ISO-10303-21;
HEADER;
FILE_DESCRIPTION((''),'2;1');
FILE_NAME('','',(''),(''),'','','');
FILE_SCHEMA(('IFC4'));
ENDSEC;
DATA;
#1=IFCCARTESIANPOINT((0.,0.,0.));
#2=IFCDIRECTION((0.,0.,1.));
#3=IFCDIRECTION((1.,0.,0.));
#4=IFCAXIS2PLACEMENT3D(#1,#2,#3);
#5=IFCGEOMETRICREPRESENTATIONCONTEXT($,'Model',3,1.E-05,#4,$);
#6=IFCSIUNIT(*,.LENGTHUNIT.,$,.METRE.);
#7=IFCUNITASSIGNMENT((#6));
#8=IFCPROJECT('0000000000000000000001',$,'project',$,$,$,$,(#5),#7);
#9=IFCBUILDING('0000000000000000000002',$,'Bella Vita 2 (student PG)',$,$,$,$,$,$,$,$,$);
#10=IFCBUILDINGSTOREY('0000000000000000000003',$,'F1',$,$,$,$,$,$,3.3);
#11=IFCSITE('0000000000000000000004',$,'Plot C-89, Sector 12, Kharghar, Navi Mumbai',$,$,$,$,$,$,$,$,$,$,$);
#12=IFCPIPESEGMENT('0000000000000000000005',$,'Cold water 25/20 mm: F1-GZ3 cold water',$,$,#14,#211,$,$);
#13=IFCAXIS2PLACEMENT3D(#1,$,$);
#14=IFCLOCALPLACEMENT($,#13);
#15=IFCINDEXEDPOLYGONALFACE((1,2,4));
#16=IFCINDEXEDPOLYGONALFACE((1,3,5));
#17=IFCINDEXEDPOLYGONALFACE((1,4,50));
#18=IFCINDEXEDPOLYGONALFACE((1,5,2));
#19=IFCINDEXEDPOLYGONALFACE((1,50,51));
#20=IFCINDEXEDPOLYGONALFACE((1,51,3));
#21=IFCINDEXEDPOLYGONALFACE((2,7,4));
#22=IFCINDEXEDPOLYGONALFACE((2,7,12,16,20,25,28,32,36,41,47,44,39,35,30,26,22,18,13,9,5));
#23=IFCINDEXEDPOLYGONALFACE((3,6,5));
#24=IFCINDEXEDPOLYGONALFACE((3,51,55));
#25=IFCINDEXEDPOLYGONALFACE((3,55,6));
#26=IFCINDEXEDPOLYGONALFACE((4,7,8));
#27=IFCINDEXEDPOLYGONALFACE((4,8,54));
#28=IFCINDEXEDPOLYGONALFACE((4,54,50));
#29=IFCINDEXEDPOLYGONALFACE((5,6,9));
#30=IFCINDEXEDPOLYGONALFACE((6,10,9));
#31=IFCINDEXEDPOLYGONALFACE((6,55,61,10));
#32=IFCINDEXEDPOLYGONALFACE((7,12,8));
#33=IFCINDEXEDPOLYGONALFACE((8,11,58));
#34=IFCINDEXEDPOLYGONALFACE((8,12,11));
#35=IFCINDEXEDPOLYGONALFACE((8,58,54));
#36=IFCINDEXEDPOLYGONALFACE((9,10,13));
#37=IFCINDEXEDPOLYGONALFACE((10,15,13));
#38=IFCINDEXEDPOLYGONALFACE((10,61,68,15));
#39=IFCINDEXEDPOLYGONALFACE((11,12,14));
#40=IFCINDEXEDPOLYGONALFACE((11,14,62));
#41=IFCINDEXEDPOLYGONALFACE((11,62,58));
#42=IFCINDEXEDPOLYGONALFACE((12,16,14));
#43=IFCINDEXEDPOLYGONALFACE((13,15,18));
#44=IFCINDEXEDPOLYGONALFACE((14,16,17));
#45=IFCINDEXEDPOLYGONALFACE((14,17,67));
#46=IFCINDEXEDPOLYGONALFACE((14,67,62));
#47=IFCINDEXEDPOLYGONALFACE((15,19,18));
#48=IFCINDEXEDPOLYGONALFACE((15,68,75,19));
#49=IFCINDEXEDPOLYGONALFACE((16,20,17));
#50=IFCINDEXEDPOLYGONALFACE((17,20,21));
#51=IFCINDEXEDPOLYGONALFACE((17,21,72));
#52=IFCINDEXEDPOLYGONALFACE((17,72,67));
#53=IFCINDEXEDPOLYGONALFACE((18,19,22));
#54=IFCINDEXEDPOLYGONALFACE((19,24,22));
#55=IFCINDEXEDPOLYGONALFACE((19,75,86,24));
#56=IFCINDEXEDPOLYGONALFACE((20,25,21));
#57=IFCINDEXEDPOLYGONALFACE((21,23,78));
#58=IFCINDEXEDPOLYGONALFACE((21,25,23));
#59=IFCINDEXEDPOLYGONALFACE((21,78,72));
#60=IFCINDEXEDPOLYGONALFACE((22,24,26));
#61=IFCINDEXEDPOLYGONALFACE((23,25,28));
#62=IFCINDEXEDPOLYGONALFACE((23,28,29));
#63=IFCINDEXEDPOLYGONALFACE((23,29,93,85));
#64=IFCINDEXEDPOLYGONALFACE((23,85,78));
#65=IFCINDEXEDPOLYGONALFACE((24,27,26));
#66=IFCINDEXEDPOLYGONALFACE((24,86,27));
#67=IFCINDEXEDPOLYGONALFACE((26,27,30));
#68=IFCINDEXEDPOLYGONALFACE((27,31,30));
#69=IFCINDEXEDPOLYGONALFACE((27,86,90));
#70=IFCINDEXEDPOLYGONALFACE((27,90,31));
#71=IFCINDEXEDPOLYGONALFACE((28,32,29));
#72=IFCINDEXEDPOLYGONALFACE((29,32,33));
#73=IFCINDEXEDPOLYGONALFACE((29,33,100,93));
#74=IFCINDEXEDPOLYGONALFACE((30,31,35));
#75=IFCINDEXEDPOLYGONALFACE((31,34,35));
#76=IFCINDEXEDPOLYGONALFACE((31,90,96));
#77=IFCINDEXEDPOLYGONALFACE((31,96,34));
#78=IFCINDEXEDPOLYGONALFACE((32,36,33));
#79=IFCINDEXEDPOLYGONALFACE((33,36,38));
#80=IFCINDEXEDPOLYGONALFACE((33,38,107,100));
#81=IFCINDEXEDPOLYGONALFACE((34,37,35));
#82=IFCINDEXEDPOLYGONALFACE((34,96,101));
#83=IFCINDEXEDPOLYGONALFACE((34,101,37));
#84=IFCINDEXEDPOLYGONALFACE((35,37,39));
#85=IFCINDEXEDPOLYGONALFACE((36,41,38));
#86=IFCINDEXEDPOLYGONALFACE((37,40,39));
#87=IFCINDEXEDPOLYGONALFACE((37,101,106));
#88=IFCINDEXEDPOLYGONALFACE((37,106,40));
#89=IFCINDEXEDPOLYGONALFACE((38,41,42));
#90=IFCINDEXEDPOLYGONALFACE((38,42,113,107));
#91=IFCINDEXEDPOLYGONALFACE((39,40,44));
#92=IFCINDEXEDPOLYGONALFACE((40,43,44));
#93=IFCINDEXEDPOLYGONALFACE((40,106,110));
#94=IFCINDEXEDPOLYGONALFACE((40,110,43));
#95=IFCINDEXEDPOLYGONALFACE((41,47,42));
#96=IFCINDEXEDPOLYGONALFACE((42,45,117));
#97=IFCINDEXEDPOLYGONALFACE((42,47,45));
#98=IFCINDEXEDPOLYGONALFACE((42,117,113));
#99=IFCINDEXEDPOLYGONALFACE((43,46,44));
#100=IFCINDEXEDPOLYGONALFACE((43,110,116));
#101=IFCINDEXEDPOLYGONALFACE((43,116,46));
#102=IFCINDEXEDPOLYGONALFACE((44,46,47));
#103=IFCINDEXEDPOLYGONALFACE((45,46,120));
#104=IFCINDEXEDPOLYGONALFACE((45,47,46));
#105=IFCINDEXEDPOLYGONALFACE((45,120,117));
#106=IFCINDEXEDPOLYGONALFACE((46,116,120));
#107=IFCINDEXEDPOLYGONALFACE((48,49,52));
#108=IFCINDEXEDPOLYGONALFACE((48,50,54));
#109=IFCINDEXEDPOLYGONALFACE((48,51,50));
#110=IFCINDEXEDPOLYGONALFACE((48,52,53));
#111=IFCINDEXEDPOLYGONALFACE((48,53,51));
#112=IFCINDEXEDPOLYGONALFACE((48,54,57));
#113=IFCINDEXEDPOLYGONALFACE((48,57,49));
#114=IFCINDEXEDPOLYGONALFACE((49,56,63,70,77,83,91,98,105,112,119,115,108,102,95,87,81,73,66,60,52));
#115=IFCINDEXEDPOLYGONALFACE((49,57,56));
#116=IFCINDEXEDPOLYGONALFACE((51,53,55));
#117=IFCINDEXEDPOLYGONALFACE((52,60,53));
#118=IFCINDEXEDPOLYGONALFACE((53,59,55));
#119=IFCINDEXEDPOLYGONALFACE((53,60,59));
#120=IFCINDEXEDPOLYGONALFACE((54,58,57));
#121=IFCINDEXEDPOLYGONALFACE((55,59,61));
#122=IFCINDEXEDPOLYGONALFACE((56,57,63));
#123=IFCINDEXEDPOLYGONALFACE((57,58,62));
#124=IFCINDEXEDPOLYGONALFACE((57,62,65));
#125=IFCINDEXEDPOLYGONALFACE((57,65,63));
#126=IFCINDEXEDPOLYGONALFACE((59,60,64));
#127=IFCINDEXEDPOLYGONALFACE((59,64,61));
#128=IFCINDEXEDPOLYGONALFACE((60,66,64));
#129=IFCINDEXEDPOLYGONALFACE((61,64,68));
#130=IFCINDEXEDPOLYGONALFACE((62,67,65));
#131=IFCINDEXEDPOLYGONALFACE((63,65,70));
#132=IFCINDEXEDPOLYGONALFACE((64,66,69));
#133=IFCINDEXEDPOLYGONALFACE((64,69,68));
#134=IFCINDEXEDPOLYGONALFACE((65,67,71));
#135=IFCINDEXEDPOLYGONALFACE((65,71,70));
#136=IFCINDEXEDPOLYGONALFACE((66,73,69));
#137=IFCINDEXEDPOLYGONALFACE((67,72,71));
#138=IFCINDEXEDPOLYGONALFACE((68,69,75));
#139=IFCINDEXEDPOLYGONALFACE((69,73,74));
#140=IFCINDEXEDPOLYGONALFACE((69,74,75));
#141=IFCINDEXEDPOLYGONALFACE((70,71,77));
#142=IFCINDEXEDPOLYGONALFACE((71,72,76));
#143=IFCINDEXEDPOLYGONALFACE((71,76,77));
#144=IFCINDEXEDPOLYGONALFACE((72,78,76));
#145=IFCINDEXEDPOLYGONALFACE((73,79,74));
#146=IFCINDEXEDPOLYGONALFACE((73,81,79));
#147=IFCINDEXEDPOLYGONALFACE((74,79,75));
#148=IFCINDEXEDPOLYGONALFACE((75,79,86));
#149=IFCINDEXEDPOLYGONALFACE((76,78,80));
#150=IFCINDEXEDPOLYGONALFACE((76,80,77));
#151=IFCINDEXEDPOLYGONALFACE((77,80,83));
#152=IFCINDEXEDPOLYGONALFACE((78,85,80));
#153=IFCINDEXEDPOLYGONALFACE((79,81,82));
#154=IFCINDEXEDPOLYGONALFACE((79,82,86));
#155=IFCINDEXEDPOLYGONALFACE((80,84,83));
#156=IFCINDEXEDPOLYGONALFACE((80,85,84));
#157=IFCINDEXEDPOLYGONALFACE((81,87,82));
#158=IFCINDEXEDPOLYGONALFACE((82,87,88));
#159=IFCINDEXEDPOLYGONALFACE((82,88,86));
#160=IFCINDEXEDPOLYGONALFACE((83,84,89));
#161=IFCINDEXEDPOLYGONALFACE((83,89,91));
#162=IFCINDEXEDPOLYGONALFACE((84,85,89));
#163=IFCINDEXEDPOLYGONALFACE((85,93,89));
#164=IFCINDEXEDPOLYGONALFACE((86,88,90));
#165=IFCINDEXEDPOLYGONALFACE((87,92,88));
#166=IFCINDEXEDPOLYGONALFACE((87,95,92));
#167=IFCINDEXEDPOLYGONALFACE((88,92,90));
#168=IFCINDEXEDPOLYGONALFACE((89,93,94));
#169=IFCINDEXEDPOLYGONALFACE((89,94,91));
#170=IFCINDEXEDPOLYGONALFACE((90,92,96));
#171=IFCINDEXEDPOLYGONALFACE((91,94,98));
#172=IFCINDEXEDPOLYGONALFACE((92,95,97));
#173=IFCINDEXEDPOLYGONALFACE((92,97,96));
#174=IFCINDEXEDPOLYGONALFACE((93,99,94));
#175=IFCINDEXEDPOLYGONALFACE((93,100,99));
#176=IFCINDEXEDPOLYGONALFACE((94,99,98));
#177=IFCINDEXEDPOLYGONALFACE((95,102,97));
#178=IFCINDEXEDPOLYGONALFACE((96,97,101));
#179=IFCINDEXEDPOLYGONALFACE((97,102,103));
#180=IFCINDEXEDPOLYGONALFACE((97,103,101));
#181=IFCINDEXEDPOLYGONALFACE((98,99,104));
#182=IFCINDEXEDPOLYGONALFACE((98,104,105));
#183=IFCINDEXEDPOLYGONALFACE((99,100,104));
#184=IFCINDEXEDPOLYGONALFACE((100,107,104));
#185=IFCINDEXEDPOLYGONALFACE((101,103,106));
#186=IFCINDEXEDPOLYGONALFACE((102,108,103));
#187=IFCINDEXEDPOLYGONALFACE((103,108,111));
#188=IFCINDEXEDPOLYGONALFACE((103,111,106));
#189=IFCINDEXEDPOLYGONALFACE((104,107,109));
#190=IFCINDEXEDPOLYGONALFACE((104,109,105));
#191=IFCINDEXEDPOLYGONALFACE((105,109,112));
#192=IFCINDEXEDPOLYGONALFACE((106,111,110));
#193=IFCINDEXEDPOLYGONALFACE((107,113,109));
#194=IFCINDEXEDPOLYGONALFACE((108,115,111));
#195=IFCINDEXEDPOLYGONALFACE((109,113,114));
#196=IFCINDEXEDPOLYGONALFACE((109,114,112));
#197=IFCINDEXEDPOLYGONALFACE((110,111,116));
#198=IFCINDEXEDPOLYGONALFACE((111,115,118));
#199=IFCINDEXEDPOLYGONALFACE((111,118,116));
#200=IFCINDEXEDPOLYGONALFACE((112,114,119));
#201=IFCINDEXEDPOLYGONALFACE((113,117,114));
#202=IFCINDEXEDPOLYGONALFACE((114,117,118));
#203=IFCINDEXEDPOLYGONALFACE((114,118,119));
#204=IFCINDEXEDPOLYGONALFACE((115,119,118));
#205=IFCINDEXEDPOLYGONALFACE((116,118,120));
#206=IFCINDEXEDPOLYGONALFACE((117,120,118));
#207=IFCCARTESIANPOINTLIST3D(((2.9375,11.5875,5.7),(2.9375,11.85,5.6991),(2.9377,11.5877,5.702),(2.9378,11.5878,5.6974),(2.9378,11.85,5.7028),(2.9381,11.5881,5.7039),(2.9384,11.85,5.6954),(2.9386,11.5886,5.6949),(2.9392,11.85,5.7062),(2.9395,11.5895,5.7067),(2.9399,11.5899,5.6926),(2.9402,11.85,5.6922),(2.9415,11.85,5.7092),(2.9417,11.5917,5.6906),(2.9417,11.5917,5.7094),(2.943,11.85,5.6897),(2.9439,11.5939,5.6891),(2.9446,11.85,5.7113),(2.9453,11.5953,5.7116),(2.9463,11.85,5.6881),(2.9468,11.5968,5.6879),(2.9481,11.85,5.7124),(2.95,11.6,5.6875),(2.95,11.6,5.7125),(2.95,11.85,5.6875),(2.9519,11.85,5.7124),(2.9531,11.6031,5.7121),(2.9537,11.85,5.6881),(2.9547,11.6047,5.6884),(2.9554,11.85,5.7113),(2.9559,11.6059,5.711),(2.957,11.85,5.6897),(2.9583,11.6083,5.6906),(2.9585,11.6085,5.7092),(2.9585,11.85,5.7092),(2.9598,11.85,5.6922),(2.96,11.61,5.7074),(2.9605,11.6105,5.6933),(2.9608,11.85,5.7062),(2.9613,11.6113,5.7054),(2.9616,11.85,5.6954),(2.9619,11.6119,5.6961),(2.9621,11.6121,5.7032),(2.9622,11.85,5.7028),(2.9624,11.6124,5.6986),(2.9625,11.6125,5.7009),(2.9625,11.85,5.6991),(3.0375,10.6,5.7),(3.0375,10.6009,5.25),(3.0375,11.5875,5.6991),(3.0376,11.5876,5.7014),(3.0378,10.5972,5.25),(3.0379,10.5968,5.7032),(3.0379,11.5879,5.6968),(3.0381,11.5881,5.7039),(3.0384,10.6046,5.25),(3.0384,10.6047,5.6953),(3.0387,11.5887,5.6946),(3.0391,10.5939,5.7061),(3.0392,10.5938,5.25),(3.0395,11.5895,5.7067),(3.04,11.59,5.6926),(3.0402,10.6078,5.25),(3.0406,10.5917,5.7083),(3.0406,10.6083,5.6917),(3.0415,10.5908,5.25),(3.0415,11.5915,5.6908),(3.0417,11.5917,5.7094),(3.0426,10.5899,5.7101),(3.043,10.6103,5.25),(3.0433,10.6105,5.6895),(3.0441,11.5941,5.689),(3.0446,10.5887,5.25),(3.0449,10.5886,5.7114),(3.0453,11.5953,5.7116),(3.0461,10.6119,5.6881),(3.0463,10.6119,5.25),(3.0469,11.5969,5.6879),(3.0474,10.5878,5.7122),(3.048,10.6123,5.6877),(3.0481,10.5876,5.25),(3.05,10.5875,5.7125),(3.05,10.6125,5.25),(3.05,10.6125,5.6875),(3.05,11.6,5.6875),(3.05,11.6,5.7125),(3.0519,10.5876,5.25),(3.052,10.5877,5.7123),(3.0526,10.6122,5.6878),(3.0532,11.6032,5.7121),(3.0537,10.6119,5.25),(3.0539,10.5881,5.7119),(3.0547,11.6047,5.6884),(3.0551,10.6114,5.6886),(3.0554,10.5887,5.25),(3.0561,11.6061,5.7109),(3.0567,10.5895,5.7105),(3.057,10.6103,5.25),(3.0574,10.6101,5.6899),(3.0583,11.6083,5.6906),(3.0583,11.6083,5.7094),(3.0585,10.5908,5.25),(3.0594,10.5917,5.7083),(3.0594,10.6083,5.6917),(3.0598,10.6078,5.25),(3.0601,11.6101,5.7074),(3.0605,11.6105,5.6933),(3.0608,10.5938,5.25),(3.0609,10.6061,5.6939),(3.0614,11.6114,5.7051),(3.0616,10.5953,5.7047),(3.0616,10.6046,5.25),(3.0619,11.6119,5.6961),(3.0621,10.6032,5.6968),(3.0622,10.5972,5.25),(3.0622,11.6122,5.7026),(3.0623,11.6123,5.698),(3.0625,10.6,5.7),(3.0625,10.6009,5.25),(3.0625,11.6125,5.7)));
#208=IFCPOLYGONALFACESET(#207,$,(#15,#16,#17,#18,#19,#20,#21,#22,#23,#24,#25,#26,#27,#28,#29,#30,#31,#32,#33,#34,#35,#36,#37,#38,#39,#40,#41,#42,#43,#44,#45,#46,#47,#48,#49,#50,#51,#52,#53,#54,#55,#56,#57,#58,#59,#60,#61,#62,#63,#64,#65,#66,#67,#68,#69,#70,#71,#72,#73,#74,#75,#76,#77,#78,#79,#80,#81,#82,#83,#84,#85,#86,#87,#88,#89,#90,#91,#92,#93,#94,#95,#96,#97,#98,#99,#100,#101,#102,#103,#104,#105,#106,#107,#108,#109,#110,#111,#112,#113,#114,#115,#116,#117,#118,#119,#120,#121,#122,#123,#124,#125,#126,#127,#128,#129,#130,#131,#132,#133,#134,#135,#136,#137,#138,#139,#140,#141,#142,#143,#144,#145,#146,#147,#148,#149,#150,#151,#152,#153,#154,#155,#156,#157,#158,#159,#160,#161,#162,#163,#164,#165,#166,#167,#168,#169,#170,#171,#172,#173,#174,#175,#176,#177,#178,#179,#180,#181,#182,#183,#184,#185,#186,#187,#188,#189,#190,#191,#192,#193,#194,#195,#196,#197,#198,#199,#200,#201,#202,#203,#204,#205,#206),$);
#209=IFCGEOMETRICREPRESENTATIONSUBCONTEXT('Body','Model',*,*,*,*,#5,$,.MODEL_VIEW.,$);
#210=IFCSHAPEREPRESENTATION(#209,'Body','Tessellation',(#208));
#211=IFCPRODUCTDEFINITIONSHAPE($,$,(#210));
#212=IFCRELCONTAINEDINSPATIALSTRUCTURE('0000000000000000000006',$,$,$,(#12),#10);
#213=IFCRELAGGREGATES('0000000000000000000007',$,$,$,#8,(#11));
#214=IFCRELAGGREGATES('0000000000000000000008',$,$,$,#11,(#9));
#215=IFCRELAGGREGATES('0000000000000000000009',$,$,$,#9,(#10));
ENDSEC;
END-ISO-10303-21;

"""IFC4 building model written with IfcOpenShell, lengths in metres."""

from ifc_helpers import new_model, entity, si_unit, origin, origin_with_axes, place, context, subcontext, project, spatial, element, save


model = new_model("IFC4")

# Units and contexts
model_context = context("Model", 3, precision=1e-05, world=origin_with_axes())
body_context = subcontext(model_context, "Body", "Model", "MODEL_VIEW")
ifc_project = project(units=[si_unit("LENGTHUNIT", "METRE")], contexts=[model_context])

# Site, building, storey
site = spatial("IfcSite", under=ifc_project, Name="Plot C-89, Sector 12, Kharghar, Navi Mumbai")
building = spatial("IfcBuilding", under=site, Name="Bella Vita 2 (student PG)")
storey = spatial("IfcBuildingStorey", under=building, Name="F1", Elevation=3.3)

# Pipe segment
pipe_segment_1_placement = place(None, origin())
element("IfcPipeSegment", 1, at=pipe_segment_1_placement, inside=storey, Name="Cold water 25/20 mm: F1-GZ3 cold water", context=body_context, shape_type="AdvancedSweptSolid", body=[
    entity("IfcSweptDiskSolid", entity("IfcPolyline", [entity("IfcCartesianPoint", [2.95, 11.85, 5.7]), entity("IfcCartesianPoint", [2.95, 11.6, 5.7]), entity("IfcCartesianPoint", [3.05, 11.6, 5.7]), entity("IfcCartesianPoint", [3.05, 10.6, 5.7]), entity("IfcCartesianPoint", [3.05, 10.6, 5.25])]), 0.0125),
])

save(model, "model.ifc")
